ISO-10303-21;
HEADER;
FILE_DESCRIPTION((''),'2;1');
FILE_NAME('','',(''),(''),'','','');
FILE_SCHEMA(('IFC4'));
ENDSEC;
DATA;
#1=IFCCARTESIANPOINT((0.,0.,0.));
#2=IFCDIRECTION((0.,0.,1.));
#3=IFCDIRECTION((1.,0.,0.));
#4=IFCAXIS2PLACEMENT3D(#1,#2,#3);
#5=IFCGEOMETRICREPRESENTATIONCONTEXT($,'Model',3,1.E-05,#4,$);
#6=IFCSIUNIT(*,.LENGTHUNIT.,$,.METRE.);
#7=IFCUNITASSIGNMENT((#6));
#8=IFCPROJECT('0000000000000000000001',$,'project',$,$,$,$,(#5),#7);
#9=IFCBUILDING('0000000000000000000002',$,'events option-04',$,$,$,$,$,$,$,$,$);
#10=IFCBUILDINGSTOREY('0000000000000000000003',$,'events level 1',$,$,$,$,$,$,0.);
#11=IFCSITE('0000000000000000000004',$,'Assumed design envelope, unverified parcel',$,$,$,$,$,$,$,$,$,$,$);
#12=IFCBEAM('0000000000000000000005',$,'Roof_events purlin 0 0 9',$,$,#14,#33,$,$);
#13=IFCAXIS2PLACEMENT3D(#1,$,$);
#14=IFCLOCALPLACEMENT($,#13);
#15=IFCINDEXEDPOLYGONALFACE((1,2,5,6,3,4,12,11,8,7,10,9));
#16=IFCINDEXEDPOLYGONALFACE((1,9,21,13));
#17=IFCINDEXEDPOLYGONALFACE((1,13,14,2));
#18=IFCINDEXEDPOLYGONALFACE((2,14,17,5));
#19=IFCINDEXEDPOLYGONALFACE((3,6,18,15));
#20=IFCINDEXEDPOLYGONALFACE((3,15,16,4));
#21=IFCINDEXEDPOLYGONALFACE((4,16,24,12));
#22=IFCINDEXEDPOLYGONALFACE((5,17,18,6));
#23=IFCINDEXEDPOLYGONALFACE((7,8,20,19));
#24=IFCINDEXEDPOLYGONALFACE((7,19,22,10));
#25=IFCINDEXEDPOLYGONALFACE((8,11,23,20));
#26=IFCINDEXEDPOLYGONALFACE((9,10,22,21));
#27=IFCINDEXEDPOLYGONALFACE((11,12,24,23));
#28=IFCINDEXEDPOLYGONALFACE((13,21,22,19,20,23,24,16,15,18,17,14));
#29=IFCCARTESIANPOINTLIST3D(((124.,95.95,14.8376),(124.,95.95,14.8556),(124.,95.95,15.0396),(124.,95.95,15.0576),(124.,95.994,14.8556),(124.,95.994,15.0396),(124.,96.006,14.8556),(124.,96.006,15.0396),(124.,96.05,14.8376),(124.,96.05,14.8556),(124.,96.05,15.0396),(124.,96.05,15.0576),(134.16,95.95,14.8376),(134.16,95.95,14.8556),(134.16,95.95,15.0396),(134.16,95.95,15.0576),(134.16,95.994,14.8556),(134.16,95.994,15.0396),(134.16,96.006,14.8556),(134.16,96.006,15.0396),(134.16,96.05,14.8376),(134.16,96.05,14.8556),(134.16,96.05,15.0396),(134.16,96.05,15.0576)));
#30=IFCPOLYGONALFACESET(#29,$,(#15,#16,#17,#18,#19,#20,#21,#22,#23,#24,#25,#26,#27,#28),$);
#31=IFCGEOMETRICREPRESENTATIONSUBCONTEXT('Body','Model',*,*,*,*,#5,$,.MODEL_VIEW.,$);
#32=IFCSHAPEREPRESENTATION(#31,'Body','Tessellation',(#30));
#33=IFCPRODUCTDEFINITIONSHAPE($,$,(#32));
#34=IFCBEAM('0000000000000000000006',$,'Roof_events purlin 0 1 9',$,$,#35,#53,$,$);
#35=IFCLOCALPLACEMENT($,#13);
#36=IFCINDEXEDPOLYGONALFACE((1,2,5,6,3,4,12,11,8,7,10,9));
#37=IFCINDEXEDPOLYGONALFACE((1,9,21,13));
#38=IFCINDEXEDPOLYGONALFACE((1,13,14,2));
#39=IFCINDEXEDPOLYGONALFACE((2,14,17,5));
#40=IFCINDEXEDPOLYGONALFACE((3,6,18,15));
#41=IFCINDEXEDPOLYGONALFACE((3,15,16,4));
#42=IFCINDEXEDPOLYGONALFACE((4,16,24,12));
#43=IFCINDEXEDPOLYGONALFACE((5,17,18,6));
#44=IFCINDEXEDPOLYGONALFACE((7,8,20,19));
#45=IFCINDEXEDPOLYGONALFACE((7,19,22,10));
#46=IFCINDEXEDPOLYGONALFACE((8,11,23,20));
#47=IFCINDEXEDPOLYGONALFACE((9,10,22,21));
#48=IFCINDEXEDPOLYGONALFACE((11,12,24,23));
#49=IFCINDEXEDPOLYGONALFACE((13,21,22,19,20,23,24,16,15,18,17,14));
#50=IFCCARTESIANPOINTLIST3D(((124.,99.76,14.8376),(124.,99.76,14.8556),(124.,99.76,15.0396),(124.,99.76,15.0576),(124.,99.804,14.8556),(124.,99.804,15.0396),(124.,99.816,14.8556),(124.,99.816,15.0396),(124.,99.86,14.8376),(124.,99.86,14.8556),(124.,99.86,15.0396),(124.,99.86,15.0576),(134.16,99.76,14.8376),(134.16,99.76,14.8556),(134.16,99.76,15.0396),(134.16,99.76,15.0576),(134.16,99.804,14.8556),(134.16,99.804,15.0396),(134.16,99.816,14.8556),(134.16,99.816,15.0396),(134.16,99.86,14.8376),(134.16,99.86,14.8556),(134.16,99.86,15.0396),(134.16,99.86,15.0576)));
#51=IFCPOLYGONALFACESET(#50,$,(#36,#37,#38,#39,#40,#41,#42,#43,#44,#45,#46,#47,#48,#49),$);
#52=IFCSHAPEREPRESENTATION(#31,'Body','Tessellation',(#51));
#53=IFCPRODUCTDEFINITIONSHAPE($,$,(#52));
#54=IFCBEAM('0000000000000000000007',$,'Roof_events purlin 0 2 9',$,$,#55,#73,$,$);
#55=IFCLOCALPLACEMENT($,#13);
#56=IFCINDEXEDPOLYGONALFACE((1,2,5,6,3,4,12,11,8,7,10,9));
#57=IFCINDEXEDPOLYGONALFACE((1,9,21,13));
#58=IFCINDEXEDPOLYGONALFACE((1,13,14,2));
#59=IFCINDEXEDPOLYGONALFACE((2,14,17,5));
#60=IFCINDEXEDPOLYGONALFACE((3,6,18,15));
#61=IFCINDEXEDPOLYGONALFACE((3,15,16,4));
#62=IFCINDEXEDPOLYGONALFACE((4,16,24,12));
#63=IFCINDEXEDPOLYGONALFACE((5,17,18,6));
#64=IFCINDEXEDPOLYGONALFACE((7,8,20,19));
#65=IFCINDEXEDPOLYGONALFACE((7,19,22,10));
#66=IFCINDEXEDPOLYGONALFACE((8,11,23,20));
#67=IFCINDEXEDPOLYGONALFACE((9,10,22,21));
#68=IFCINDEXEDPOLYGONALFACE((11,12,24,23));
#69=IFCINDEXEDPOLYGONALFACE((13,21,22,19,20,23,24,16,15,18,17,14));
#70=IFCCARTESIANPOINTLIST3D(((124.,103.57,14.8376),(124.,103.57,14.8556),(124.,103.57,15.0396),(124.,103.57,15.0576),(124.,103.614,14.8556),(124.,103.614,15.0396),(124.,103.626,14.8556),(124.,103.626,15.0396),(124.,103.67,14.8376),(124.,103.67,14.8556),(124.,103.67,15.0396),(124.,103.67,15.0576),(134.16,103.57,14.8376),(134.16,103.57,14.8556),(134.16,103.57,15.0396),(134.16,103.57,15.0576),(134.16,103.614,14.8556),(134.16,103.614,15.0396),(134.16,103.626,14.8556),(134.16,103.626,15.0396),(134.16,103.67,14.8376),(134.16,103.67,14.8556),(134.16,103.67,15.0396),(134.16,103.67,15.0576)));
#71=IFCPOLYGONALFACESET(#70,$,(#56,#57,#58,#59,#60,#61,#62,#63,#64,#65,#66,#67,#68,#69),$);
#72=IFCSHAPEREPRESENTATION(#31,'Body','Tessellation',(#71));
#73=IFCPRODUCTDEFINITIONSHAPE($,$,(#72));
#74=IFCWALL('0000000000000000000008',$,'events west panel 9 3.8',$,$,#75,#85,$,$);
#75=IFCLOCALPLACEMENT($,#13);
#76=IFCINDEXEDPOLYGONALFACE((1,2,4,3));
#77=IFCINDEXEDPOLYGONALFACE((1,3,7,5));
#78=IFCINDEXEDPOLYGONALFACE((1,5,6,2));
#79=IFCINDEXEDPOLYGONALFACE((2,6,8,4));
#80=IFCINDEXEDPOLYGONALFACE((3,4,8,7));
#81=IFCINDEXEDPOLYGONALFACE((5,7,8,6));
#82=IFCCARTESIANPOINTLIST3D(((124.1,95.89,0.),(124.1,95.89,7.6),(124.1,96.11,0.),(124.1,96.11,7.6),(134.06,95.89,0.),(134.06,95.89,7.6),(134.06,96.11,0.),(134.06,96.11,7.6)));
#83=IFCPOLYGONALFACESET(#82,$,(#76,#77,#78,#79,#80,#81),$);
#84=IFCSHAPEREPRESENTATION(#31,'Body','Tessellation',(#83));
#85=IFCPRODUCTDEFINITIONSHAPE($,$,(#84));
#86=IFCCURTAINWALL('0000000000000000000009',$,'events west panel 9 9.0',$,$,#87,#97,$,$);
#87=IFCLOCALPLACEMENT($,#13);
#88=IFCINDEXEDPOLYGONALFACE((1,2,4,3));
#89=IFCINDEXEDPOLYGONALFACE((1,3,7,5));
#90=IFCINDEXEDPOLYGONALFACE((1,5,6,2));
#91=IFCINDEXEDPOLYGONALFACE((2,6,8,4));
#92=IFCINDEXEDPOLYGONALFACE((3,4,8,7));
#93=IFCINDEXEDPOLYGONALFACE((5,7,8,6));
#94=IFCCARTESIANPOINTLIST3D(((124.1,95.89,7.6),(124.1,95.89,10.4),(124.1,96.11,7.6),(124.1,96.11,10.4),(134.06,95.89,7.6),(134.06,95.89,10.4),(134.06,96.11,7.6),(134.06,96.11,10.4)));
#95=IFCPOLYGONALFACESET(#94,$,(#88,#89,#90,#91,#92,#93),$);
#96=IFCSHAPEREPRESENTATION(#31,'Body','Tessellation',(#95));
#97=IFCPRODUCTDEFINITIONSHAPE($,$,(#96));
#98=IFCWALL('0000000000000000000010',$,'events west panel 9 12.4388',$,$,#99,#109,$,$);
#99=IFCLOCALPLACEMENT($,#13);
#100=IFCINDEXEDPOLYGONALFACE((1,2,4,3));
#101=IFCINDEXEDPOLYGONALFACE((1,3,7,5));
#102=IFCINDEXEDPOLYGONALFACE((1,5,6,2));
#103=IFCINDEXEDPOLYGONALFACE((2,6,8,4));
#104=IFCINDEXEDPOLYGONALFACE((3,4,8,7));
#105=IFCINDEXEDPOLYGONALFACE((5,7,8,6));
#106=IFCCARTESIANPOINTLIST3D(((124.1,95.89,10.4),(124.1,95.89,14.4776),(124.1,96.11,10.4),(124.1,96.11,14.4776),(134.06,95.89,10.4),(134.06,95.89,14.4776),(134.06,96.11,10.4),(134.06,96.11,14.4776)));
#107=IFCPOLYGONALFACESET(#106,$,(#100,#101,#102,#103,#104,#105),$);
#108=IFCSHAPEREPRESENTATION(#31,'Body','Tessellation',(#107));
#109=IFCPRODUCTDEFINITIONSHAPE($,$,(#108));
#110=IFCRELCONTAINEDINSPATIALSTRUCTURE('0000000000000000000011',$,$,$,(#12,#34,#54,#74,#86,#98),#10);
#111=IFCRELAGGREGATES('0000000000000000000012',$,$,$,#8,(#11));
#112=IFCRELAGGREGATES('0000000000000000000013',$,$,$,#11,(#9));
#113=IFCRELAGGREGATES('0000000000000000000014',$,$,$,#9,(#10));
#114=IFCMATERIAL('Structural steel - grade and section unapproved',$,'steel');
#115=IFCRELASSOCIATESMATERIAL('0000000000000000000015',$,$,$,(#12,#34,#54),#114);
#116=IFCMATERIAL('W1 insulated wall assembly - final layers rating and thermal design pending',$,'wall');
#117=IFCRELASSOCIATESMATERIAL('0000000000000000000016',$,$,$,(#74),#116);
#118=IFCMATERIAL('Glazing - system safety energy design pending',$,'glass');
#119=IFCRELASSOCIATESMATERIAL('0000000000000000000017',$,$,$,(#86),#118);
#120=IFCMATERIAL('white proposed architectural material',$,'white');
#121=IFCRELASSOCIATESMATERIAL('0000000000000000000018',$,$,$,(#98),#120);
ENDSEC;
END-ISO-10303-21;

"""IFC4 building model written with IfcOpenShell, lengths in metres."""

from ifc_helpers import new_model, si_unit, frame, origin_with_axes, place, context, subcontext, project, spatial, rectangle, i_section, extrude, material, element, save


model = new_model("IFC4")

# Units and contexts
model_context = context("Model", 3, precision=1e-05, world=origin_with_axes())
body_context = subcontext(model_context, "Body", "Model", "MODEL_VIEW")
ifc_project = project(units=[si_unit("LENGTHUNIT", "METRE")], contexts=[model_context])

# Site, building, storey
site = spatial("IfcSite", under=ifc_project, Name="Assumed design envelope, unverified parcel")
building = spatial("IfcBuilding", under=site, Name="events option-04")
storey = spatial("IfcBuildingStorey", under=building, Name="events level 1", Elevation=0.0)

# Shared definitions
ifc_material_1 = material(Name="Structural steel - grade and section unapproved", Category="steel")

# Beams
for number, where, z_axis, x_axis, name in (
    (1, (134.16, 96.0, 14.9476), (-1.0, 0.0, 0.0), (0.0, -1.0, 0.0), "Roof_events purlin 0 0 9"),
    (2, (134.16, 99.81, 14.9476), (-1.0, 0.0, 0.0), (0.0, -1.0, 0.0), "Roof_events purlin 0 1 9"),
    (3, (134.16, 103.62, 14.9476), (-1.0, 0.0, 0.0), (0.0, -1.0, 0.0), "Roof_events purlin 0 2 9"),
):
    element("IfcBeam", number, at=place(None, frame(where, z_axis=z_axis, x_axis=x_axis)), inside=storey, material=ifc_material_1, Name=name, context=body_context, shape_type="SweptSolid", body=[
        extrude(i_section(OverallWidth=0.1, OverallDepth=0.22, WebThickness=0.012, FlangeThickness=0.018, FilletRadius=0.0), origin_with_axes(), (0.0, 0.0, 1.0), 10.16),
    ])

# Wall
ifc_material_2 = material(Name="W1 insulated wall assembly - final layers rating and thermal design pending", Category="wall")
wall_1_placement = place(None, frame((129.08, 96.0, 0.0), z_axis=(0.0, 0.0, 1.0), x_axis=(0.0, 1.0, 0.0)))
element("IfcWall", 4, at=wall_1_placement, inside=storey, material=ifc_material_2, Name="events west panel 9 3.8", context=body_context, shape_type="SweptSolid", body=[
    extrude(rectangle(XDim=0.22, YDim=9.96), origin_with_axes(), (0.0, 0.0, 1.0), 7.6),
])

# Curtain wall
ifc_material_3 = material(Name="Glazing - system safety energy design pending", Category="glass")
curtain_wall_placement = place(None, frame((129.08, 96.0, 7.6), z_axis=(0.0, 0.0, 1.0), x_axis=(0.0, 1.0, 0.0)))
element("IfcCurtainWall", 5, at=curtain_wall_placement, inside=storey, material=ifc_material_3, Name="events west panel 9 9.0", context=body_context, shape_type="SweptSolid", body=[
    extrude(rectangle(XDim=0.22, YDim=9.96), origin_with_axes(), (0.0, 0.0, 1.0), 2.8),
])

# Wall
ifc_material_4 = material(Name="white proposed architectural material", Category="white")
wall_2_placement = place(None, frame((129.08, 96.0, 10.4), z_axis=(0.0, 0.0, 1.0), x_axis=(0.0, 1.0, 0.0)))
element("IfcWall", 6, at=wall_2_placement, inside=storey, material=ifc_material_4, Name="events west panel 9 12.4388", context=body_context, shape_type="SweptSolid", body=[
    extrude(rectangle(XDim=0.22, YDim=9.96), origin_with_axes(), (0.0, 0.0, 1.0), 4.0776),
])

save(model, "model.ifc")
